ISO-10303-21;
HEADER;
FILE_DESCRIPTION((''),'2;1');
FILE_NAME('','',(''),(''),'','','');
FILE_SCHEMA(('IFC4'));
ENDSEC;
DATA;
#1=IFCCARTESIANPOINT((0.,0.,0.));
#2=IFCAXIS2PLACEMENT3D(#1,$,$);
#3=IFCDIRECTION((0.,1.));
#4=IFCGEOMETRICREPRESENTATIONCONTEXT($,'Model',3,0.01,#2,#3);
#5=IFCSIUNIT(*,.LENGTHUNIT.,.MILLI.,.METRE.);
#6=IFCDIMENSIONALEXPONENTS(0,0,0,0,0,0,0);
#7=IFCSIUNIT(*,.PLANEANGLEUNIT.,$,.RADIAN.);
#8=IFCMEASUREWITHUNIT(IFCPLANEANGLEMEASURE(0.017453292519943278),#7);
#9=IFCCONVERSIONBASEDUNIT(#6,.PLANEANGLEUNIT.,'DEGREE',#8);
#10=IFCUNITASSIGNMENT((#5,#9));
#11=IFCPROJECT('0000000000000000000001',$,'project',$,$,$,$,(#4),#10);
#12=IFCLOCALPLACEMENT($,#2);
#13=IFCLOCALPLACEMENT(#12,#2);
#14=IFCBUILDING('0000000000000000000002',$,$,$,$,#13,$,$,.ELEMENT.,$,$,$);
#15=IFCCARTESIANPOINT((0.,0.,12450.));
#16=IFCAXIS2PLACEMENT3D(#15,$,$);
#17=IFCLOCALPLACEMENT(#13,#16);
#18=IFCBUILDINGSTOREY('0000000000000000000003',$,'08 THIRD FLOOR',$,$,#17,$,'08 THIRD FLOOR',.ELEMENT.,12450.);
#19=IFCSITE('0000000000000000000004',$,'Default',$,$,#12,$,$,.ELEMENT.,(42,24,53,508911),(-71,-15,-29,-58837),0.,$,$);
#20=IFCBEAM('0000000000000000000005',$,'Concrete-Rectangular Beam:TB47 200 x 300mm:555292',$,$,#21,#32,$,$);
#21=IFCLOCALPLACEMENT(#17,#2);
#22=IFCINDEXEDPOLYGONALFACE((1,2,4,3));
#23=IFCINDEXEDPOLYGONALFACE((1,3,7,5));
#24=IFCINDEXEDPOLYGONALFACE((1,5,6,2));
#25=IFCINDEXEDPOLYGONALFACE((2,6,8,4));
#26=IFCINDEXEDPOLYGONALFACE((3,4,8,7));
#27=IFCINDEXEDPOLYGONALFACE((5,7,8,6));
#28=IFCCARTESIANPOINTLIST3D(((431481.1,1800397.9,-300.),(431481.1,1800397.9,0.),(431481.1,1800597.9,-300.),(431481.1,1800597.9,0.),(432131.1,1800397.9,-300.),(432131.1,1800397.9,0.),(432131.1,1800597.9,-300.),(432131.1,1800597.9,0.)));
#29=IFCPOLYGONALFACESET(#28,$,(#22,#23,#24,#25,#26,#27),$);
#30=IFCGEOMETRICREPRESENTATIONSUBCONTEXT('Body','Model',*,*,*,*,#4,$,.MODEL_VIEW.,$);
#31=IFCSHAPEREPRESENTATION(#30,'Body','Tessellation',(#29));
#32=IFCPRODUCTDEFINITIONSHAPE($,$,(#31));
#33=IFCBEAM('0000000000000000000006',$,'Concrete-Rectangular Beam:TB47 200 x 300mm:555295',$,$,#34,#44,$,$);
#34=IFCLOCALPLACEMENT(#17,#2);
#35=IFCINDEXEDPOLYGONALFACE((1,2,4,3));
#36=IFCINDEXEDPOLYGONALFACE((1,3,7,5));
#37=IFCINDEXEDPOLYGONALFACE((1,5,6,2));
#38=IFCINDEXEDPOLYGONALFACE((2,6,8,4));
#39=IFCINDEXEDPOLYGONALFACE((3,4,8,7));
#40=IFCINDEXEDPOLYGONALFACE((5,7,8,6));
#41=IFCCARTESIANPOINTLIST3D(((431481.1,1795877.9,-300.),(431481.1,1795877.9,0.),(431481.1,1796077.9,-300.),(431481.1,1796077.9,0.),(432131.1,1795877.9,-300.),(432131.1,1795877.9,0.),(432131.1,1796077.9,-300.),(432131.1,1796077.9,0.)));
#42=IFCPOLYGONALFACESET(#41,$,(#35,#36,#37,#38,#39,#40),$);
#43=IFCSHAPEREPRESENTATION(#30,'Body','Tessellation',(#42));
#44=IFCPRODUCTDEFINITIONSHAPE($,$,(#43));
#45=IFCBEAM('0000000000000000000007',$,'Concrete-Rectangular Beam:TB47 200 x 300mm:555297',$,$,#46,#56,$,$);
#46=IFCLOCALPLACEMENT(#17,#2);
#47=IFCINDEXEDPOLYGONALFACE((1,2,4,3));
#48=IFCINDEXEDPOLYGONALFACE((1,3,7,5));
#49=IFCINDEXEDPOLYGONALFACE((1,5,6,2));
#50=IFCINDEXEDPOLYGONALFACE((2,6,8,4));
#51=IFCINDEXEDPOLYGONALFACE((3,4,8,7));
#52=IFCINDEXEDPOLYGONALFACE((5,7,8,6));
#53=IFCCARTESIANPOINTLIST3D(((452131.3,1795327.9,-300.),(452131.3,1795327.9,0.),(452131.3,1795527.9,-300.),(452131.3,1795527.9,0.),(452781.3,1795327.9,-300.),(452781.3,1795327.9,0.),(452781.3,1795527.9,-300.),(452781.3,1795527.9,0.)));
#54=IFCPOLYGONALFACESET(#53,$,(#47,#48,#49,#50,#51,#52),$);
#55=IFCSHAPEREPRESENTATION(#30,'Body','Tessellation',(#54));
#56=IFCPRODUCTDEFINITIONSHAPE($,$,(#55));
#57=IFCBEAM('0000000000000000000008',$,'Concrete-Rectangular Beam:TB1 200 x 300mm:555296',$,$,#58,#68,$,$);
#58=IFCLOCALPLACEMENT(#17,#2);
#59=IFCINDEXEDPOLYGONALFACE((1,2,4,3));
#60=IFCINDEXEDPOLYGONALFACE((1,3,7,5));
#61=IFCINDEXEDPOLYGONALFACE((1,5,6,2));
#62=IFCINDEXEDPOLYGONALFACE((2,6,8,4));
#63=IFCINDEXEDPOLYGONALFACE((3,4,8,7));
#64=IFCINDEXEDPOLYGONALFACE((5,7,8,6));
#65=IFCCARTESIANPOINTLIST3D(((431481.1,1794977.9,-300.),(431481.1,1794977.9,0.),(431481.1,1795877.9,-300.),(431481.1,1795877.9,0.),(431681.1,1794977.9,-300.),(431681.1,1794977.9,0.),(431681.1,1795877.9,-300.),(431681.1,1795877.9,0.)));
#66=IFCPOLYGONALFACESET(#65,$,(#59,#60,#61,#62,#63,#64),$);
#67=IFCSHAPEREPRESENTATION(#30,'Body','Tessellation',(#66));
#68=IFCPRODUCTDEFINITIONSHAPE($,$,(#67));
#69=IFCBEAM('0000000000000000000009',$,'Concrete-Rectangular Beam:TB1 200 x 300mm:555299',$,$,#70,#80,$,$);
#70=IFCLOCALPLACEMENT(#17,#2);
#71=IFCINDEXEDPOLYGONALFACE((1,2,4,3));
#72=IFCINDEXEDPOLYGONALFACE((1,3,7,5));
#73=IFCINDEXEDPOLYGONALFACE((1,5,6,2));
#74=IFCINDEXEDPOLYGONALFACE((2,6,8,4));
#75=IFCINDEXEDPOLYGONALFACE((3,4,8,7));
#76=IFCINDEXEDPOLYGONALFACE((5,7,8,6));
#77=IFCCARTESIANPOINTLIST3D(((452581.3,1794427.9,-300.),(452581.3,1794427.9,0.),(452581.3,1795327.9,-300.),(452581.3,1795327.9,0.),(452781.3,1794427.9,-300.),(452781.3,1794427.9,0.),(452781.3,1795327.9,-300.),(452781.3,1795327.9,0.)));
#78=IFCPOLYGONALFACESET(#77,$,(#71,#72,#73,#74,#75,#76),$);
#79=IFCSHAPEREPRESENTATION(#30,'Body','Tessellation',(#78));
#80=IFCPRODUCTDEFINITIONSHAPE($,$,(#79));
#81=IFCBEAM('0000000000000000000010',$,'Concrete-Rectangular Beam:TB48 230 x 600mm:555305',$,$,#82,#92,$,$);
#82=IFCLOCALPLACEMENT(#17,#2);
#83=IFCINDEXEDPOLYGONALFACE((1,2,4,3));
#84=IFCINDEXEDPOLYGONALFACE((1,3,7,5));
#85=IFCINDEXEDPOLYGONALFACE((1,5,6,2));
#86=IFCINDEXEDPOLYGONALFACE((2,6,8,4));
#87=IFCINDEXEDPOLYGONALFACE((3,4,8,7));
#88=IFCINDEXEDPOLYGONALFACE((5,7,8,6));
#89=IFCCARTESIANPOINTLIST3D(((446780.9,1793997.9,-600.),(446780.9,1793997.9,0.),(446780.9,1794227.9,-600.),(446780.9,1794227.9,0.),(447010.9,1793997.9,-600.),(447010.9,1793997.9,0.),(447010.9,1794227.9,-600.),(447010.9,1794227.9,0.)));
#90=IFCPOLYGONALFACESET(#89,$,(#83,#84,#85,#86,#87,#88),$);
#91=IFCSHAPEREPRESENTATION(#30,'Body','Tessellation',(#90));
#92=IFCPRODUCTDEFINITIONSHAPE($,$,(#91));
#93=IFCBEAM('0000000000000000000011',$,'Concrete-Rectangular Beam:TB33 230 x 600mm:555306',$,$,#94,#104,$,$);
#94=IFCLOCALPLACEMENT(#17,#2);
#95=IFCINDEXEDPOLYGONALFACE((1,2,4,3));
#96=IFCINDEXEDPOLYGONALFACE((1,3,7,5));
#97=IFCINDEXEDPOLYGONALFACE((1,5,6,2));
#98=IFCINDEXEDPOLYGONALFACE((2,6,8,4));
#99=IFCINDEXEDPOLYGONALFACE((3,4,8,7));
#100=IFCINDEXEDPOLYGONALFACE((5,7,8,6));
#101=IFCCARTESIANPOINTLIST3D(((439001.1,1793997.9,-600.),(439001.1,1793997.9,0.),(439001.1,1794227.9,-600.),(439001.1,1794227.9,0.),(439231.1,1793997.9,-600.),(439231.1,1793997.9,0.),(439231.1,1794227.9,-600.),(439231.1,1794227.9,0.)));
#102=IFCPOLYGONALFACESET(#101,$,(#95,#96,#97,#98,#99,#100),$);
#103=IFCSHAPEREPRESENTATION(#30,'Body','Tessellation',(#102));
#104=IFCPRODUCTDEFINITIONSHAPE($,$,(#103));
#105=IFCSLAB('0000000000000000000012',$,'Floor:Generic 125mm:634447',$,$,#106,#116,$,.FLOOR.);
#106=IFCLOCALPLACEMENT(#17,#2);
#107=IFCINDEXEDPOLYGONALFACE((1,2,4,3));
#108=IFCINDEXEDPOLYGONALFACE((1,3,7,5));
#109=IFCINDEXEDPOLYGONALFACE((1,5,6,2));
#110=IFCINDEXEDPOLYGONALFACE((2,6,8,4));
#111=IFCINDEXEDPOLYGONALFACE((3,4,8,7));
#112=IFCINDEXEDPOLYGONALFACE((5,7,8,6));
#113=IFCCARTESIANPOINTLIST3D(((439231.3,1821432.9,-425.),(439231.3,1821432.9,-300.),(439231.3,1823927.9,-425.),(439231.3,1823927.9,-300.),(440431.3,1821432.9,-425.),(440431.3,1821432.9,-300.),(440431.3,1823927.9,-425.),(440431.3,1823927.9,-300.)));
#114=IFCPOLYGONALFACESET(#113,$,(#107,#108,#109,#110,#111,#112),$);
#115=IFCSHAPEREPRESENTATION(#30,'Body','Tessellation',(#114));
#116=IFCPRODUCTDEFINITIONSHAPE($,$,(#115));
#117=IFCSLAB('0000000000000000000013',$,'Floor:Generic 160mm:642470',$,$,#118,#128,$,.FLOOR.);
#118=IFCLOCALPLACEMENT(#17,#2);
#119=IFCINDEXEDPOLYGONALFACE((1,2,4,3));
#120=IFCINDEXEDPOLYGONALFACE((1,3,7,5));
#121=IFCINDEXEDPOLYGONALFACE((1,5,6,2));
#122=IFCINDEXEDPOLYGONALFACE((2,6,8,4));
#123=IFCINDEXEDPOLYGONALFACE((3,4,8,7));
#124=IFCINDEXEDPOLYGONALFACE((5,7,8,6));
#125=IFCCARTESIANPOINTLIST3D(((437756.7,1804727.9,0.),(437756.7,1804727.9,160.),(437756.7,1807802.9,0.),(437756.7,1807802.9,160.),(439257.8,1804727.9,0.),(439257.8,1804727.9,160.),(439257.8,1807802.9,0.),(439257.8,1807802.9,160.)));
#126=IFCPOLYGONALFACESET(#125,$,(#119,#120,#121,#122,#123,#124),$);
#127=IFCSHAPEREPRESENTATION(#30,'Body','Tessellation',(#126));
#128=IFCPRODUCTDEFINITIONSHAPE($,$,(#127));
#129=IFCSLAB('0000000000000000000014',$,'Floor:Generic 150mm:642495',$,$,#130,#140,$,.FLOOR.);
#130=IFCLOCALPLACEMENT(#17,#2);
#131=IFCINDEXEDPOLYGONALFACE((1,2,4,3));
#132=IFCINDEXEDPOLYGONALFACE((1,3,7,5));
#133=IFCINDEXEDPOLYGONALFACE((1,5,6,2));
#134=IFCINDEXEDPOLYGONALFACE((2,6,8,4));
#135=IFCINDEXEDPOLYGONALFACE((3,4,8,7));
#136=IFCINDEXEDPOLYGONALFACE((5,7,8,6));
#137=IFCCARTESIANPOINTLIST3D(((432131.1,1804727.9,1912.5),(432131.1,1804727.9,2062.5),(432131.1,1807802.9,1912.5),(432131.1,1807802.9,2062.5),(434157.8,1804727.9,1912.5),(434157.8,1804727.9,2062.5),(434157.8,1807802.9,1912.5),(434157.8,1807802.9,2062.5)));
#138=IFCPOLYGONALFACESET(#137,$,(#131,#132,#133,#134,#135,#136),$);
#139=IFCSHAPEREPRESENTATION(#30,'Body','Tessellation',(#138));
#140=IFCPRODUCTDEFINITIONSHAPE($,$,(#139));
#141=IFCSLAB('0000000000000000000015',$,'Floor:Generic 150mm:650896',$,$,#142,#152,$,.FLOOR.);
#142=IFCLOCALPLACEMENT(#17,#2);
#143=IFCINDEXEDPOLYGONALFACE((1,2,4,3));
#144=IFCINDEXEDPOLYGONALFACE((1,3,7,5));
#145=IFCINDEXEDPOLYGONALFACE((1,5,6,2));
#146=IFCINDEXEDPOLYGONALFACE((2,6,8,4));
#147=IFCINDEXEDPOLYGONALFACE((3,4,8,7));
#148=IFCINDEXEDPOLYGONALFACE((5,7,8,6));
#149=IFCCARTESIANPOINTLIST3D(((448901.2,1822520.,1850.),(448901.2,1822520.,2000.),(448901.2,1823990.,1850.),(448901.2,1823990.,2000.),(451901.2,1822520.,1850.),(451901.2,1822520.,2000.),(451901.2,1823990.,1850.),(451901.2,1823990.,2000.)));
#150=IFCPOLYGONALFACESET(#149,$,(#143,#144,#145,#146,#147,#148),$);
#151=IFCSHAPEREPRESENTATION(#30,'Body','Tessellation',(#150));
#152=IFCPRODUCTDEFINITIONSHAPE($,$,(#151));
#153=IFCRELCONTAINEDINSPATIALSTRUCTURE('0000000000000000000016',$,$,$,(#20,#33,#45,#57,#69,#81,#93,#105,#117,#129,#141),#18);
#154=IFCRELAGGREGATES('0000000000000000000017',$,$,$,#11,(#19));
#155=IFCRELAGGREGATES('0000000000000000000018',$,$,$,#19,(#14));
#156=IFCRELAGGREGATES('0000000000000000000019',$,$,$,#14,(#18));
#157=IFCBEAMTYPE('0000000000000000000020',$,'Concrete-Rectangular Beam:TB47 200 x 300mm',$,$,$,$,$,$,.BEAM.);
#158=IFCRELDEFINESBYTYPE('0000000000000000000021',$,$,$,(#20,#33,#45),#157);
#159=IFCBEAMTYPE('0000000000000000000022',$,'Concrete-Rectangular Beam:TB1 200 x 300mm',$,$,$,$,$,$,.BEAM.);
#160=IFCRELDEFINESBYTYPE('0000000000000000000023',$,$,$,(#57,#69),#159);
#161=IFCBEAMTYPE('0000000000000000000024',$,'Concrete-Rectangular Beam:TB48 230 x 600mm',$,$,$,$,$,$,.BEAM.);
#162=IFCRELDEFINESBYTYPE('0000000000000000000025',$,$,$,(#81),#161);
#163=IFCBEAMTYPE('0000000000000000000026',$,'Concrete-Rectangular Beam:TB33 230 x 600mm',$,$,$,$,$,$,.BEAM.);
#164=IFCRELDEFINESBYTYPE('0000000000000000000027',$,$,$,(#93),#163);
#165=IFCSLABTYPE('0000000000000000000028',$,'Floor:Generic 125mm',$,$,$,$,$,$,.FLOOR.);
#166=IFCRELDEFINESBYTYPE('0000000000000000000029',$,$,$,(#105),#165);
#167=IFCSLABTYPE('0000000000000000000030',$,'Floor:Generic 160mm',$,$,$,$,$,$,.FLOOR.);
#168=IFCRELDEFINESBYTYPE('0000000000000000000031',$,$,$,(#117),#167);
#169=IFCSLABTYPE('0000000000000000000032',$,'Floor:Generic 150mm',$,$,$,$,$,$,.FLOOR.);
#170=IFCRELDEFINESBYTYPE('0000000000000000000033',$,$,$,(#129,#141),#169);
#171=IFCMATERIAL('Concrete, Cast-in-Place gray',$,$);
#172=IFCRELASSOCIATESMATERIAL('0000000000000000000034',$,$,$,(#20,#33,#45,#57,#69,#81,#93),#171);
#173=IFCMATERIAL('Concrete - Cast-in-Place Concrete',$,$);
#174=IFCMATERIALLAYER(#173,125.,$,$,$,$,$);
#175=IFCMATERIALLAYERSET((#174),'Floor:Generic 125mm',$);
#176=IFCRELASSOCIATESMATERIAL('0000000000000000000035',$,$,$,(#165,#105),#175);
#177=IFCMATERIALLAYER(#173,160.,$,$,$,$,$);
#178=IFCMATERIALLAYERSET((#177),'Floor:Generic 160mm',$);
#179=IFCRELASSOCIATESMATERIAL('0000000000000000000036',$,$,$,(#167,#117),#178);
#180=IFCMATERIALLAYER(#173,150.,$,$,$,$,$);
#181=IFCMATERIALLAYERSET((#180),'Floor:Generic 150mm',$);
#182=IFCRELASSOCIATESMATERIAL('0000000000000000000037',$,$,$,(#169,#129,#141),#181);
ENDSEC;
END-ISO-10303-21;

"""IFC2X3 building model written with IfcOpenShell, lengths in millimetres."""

from ifc_helpers import new_model, entity, si_unit, converted_unit, direction, frame, frame_2d, origin, place, context, subcontext, project, spatial, rectangle, extrude, material, layer, layer_set, layer_usage, type_object, element, save


model = new_model("IFC2X3")

# Units and contexts
model_context = context("Model", 3, precision=0.01, world=origin(), true_north=direction((0.0, 1.0)))
body_context = subcontext(model_context, "Body", "Model", "MODEL_VIEW")
ifc_project = project(units=[si_unit("LENGTHUNIT", "METRE", prefix="MILLI"), converted_unit("PLANEANGLEUNIT", "DEGREE", entity("IfcPlaneAngleMeasure", 0.017453292519943278), si_unit("PLANEANGLEUNIT", "RADIAN"), dimensions=[0, 0, 0, 0, 0, 0, 0])], contexts=[model_context])

# Site, building, storey
site_placement = place(None, origin())
site = spatial("IfcSite", under=ifc_project, at=site_placement, Name="Default", CompositionType="ELEMENT", RefLatitude=(42, 24, 53, 508911), RefLongitude=(-71, -15, -29, -58837), RefElevation=0.0)
building_placement = place(site_placement, origin())
building = spatial("IfcBuilding", under=site, at=building_placement, CompositionType="ELEMENT")
storey_placement = place(building_placement, frame((0.0, 0.0, 12450.0)))
storey = spatial("IfcBuildingStorey", under=building, at=storey_placement, Name="08 THIRD FLOOR", LongName="08 THIRD FLOOR", CompositionType="ELEMENT", Elevation=12450.0)

# Shared definitions
ifc_material_1 = material(Name="Concrete, Cast-in-Place gray")

# Beams
beam_type_1 = type_object("IfcBeamType", Name="Concrete-Rectangular Beam:TB47 200 x 300mm", PredefinedType="BEAM")
beam_1_placement = place(storey_placement, frame((431681.1, 1800597.9, 0.0)))
element("IfcBeam", 1, at=beam_1_placement, inside=storey, type_object=beam_type_1, material=ifc_material_1, Name="Concrete-Rectangular Beam:TB47 200 x 300mm:555292", context=body_context, shape_type="SweptSolid", body=[
    extrude(rectangle(XDim=300.0, YDim=200.0, at=frame_2d((0.0, 0.0), x_axis=(1.0, 0.0))), frame((-200.0, -100.0, -150.0), z_axis=(1.0, 0.0, 0.0), x_axis=(0.0, 0.0, -1.0)), (0.0, 0.0, 1.0), 650.0),
])
beam_2_placement = place(storey_placement, frame((431481.1, 1796077.9, 0.0)))
element("IfcBeam", 2, at=beam_2_placement, inside=storey, type_object=beam_type_1, material=ifc_material_1, Name="Concrete-Rectangular Beam:TB47 200 x 300mm:555295", context=body_context, shape_type="SweptSolid", body=[
    extrude(rectangle(XDim=300.0, YDim=200.0, at=frame_2d((0.0, 0.0), x_axis=(1.0, 0.0))), frame((0.0, -100.0, -150.0), z_axis=(1.0, 0.0, 0.0), x_axis=(0.0, 0.0, -1.0)), (0.0, 0.0, 1.0), 650.0),
])
beam_3_placement = place(storey_placement, frame((452781.3, 1795527.9, 0.0), z_axis=(0.0, 0.0, 1.0), x_axis=(-1.0, 0.0, 0.0)))
element("IfcBeam", 3, at=beam_3_placement, inside=storey, type_object=beam_type_1, material=ifc_material_1, Name="Concrete-Rectangular Beam:TB47 200 x 300mm:555297", context=body_context, shape_type="SweptSolid", body=[
    extrude(rectangle(XDim=300.0, YDim=200.0, at=frame_2d((0.0, 0.0), x_axis=(1.0, 0.0))), frame((0.0, 100.0, -150.0), z_axis=(1.0, 0.0, 0.0), x_axis=(0.0, 0.0, -1.0)), (0.0, 0.0, 1.0), 650.0),
])
beam_type_2 = type_object("IfcBeamType", Name="Concrete-Rectangular Beam:TB1 200 x 300mm", PredefinedType="BEAM")
beam_4_placement = place(storey_placement, frame((431481.1, 1794777.9, 0.0), z_axis=(0.0, 0.0, 1.0), x_axis=(0.0, 1.0, 0.0)))
element("IfcBeam", 4, at=beam_4_placement, inside=storey, type_object=beam_type_2, material=ifc_material_1, Name="Concrete-Rectangular Beam:TB1 200 x 300mm:555296", context=body_context, shape_type="SweptSolid", body=[
    extrude(rectangle(XDim=300.0, YDim=200.0, at=frame_2d((0.0, 0.0), x_axis=(1.0, 0.0))), frame((200.0, -100.0, -150.0), z_axis=(1.0, 0.0, 0.0), x_axis=(0.0, 0.0, -1.0)), (0.0, 0.0, 1.0), 900.0),
])
beam_5_placement = place(storey_placement, frame((452781.3, 1795527.9, 0.0), z_axis=(0.0, 0.0, 1.0), x_axis=(0.0, -1.0, 0.0)))
element("IfcBeam", 5, at=beam_5_placement, inside=storey, type_object=beam_type_2, material=ifc_material_1, Name="Concrete-Rectangular Beam:TB1 200 x 300mm:555299", context=body_context, shape_type="SweptSolid", body=[
    extrude(rectangle(XDim=300.0, YDim=200.0, at=frame_2d((0.0, 0.0), x_axis=(1.0, 0.0))), frame((200.0, -100.0, -150.0), z_axis=(1.0, 0.0, 0.0), x_axis=(0.0, 0.0, -1.0)), (0.0, 0.0, 1.0), 900.0),
])
beam_type_3 = type_object("IfcBeamType", Name="Concrete-Rectangular Beam:TB48 230 x 600mm", PredefinedType="BEAM")
beam_6_placement = place(storey_placement, frame((446780.9, 1793997.9, 0.0), z_axis=(0.0, 0.0, 1.0), x_axis=(0.0, 1.0, 0.0)))
element("IfcBeam", 6, at=beam_6_placement, inside=storey, type_object=beam_type_3, material=ifc_material_1, Name="Concrete-Rectangular Beam:TB48 230 x 600mm:555305", context=body_context, shape_type="SweptSolid", body=[
    extrude(rectangle(XDim=600.0, YDim=230.0, at=frame_2d((0.0, 0.0), x_axis=(1.0, 0.0))), frame((0.0, -115.0, -300.0), z_axis=(1.0, 0.0, 0.0), x_axis=(0.0, 0.0, -1.0)), (0.0, 0.0, 1.0), 230.0),
])
beam_type_4 = type_object("IfcBeamType", Name="Concrete-Rectangular Beam:TB33 230 x 600mm", PredefinedType="BEAM")
beam_7_placement = place(storey_placement, frame((439231.1, 1794227.9, 0.0), z_axis=(0.0, 0.0, 1.0), x_axis=(0.0, -1.0, 0.0)))
element("IfcBeam", 7, at=beam_7_placement, inside=storey, type_object=beam_type_4, material=ifc_material_1, Name="Concrete-Rectangular Beam:TB33 230 x 600mm:555306", context=body_context, shape_type="SweptSolid", body=[
    extrude(rectangle(XDim=600.0, YDim=230.0, at=frame_2d((0.0, 0.0), x_axis=(1.0, 0.0))), frame((0.0, -115.0, -300.0), z_axis=(1.0, 0.0, 0.0), x_axis=(0.0, 0.0, -1.0)), (0.0, 0.0, 1.0), 230.0),
])

# Slab
ifc_material_2 = material(Name="Concrete - Cast-in-Place Concrete")
ifc_layer_1 = layer(ifc_material_2, 125.0)
ifc_layer_set_1 = layer_set([ifc_layer_1], Name="Floor:Generic 125mm")
slab_type_1 = type_object("IfcSlabType", Name="Floor:Generic 125mm", PredefinedType="FLOOR", material=ifc_layer_set_1)
ifc_layer_usage_1 = layer_usage(ifc_layer_set_1, "AXIS3", "POSITIVE", 0.0)
slab_1_placement = place(storey_placement, origin())
element("IfcSlab", 8, at=slab_1_placement, inside=storey, type_object=slab_type_1, material=ifc_layer_usage_1, Name="Floor:Generic 125mm:634447", PredefinedType="FLOOR", context=body_context, shape_type="SweptSolid", body=[
    extrude(rectangle(XDim=2495.0, YDim=1200.0, at=frame_2d((0.0, 0.0), x_axis=(1.0, 0.0))), frame((439831.3, 1822680.4, -300.0), z_axis=(0.0, 0.0, -1.0), x_axis=(0.0, 1.0, 0.0)), (0.0, 0.0, 1.0), 125.0),
])

# Slab
ifc_layer_2 = layer(ifc_material_2, 160.0)
ifc_layer_set_2 = layer_set([ifc_layer_2], Name="Floor:Generic 160mm")
ifc_layer_usage_2 = layer_usage(ifc_layer_set_2, "AXIS3", "POSITIVE", 0.0)
slab_type_2 = type_object("IfcSlabType", Name="Floor:Generic 160mm", PredefinedType="FLOOR", material=ifc_layer_set_2)
slab_2_placement = place(storey_placement, origin())
element("IfcSlab", 9, at=slab_2_placement, inside=storey, type_object=slab_type_2, material=ifc_layer_usage_2, Name="Floor:Generic 160mm:642470", PredefinedType="FLOOR", context=body_context, shape_type="SweptSolid", body=[
    extrude(rectangle(XDim=3075.0, YDim=1501.1, at=frame_2d((0.0, 0.0), x_axis=(1.0, 0.0))), frame((438507.2, 1806265.4, 160.0), z_axis=(0.0, 0.0, -1.0), x_axis=(0.0, 1.0, 0.0)), (0.0, 0.0, 1.0), 160.0),
])

# Slabs
ifc_layer_3 = layer(ifc_material_2, 150.0)
ifc_layer_set_3 = layer_set([ifc_layer_3], Name="Floor:Generic 150mm")
ifc_layer_usage_3 = layer_usage(ifc_layer_set_3, "AXIS3", "POSITIVE", 0.0)
slab_type_3 = type_object("IfcSlabType", Name="Floor:Generic 150mm", PredefinedType="FLOOR", material=ifc_layer_set_3)
slab_3_placement = place(storey_placement, origin())
element("IfcSlab", 10, at=slab_3_placement, inside=storey, type_object=slab_type_3, material=ifc_layer_usage_3, Name="Floor:Generic 150mm:642495", PredefinedType="FLOOR", context=body_context, shape_type="SweptSolid", body=[
    extrude(rectangle(XDim=3075.0, YDim=2026.7, at=frame_2d((0.0, 0.0), x_axis=(1.0, 0.0))), frame((433144.4, 1806265.4, 2062.5), z_axis=(0.0, 0.0, -1.0), x_axis=(0.0, 1.0, 0.0)), (0.0, 0.0, 1.0), 150.0),
])
ifc_layer_usage_4 = layer_usage(ifc_layer_set_3, "AXIS3", "POSITIVE", 0.0)
slab_4_placement = place(storey_placement, origin())
element("IfcSlab", 11, at=slab_4_placement, inside=storey, type_object=slab_type_3, material=ifc_layer_usage_4, Name="Floor:Generic 150mm:650896", PredefinedType="FLOOR", context=body_context, shape_type="SweptSolid", body=[
    extrude(rectangle(XDim=1470.0, YDim=3000.0, at=frame_2d((0.0, 0.0), x_axis=(1.0, 0.0))), frame((450401.2, 1823255.0, 2000.0), z_axis=(0.0, 0.0, -1.0), x_axis=(0.0, 1.0, 0.0)), (0.0, 0.0, 1.0), 150.0),
])

save(model, "model.ifc")
